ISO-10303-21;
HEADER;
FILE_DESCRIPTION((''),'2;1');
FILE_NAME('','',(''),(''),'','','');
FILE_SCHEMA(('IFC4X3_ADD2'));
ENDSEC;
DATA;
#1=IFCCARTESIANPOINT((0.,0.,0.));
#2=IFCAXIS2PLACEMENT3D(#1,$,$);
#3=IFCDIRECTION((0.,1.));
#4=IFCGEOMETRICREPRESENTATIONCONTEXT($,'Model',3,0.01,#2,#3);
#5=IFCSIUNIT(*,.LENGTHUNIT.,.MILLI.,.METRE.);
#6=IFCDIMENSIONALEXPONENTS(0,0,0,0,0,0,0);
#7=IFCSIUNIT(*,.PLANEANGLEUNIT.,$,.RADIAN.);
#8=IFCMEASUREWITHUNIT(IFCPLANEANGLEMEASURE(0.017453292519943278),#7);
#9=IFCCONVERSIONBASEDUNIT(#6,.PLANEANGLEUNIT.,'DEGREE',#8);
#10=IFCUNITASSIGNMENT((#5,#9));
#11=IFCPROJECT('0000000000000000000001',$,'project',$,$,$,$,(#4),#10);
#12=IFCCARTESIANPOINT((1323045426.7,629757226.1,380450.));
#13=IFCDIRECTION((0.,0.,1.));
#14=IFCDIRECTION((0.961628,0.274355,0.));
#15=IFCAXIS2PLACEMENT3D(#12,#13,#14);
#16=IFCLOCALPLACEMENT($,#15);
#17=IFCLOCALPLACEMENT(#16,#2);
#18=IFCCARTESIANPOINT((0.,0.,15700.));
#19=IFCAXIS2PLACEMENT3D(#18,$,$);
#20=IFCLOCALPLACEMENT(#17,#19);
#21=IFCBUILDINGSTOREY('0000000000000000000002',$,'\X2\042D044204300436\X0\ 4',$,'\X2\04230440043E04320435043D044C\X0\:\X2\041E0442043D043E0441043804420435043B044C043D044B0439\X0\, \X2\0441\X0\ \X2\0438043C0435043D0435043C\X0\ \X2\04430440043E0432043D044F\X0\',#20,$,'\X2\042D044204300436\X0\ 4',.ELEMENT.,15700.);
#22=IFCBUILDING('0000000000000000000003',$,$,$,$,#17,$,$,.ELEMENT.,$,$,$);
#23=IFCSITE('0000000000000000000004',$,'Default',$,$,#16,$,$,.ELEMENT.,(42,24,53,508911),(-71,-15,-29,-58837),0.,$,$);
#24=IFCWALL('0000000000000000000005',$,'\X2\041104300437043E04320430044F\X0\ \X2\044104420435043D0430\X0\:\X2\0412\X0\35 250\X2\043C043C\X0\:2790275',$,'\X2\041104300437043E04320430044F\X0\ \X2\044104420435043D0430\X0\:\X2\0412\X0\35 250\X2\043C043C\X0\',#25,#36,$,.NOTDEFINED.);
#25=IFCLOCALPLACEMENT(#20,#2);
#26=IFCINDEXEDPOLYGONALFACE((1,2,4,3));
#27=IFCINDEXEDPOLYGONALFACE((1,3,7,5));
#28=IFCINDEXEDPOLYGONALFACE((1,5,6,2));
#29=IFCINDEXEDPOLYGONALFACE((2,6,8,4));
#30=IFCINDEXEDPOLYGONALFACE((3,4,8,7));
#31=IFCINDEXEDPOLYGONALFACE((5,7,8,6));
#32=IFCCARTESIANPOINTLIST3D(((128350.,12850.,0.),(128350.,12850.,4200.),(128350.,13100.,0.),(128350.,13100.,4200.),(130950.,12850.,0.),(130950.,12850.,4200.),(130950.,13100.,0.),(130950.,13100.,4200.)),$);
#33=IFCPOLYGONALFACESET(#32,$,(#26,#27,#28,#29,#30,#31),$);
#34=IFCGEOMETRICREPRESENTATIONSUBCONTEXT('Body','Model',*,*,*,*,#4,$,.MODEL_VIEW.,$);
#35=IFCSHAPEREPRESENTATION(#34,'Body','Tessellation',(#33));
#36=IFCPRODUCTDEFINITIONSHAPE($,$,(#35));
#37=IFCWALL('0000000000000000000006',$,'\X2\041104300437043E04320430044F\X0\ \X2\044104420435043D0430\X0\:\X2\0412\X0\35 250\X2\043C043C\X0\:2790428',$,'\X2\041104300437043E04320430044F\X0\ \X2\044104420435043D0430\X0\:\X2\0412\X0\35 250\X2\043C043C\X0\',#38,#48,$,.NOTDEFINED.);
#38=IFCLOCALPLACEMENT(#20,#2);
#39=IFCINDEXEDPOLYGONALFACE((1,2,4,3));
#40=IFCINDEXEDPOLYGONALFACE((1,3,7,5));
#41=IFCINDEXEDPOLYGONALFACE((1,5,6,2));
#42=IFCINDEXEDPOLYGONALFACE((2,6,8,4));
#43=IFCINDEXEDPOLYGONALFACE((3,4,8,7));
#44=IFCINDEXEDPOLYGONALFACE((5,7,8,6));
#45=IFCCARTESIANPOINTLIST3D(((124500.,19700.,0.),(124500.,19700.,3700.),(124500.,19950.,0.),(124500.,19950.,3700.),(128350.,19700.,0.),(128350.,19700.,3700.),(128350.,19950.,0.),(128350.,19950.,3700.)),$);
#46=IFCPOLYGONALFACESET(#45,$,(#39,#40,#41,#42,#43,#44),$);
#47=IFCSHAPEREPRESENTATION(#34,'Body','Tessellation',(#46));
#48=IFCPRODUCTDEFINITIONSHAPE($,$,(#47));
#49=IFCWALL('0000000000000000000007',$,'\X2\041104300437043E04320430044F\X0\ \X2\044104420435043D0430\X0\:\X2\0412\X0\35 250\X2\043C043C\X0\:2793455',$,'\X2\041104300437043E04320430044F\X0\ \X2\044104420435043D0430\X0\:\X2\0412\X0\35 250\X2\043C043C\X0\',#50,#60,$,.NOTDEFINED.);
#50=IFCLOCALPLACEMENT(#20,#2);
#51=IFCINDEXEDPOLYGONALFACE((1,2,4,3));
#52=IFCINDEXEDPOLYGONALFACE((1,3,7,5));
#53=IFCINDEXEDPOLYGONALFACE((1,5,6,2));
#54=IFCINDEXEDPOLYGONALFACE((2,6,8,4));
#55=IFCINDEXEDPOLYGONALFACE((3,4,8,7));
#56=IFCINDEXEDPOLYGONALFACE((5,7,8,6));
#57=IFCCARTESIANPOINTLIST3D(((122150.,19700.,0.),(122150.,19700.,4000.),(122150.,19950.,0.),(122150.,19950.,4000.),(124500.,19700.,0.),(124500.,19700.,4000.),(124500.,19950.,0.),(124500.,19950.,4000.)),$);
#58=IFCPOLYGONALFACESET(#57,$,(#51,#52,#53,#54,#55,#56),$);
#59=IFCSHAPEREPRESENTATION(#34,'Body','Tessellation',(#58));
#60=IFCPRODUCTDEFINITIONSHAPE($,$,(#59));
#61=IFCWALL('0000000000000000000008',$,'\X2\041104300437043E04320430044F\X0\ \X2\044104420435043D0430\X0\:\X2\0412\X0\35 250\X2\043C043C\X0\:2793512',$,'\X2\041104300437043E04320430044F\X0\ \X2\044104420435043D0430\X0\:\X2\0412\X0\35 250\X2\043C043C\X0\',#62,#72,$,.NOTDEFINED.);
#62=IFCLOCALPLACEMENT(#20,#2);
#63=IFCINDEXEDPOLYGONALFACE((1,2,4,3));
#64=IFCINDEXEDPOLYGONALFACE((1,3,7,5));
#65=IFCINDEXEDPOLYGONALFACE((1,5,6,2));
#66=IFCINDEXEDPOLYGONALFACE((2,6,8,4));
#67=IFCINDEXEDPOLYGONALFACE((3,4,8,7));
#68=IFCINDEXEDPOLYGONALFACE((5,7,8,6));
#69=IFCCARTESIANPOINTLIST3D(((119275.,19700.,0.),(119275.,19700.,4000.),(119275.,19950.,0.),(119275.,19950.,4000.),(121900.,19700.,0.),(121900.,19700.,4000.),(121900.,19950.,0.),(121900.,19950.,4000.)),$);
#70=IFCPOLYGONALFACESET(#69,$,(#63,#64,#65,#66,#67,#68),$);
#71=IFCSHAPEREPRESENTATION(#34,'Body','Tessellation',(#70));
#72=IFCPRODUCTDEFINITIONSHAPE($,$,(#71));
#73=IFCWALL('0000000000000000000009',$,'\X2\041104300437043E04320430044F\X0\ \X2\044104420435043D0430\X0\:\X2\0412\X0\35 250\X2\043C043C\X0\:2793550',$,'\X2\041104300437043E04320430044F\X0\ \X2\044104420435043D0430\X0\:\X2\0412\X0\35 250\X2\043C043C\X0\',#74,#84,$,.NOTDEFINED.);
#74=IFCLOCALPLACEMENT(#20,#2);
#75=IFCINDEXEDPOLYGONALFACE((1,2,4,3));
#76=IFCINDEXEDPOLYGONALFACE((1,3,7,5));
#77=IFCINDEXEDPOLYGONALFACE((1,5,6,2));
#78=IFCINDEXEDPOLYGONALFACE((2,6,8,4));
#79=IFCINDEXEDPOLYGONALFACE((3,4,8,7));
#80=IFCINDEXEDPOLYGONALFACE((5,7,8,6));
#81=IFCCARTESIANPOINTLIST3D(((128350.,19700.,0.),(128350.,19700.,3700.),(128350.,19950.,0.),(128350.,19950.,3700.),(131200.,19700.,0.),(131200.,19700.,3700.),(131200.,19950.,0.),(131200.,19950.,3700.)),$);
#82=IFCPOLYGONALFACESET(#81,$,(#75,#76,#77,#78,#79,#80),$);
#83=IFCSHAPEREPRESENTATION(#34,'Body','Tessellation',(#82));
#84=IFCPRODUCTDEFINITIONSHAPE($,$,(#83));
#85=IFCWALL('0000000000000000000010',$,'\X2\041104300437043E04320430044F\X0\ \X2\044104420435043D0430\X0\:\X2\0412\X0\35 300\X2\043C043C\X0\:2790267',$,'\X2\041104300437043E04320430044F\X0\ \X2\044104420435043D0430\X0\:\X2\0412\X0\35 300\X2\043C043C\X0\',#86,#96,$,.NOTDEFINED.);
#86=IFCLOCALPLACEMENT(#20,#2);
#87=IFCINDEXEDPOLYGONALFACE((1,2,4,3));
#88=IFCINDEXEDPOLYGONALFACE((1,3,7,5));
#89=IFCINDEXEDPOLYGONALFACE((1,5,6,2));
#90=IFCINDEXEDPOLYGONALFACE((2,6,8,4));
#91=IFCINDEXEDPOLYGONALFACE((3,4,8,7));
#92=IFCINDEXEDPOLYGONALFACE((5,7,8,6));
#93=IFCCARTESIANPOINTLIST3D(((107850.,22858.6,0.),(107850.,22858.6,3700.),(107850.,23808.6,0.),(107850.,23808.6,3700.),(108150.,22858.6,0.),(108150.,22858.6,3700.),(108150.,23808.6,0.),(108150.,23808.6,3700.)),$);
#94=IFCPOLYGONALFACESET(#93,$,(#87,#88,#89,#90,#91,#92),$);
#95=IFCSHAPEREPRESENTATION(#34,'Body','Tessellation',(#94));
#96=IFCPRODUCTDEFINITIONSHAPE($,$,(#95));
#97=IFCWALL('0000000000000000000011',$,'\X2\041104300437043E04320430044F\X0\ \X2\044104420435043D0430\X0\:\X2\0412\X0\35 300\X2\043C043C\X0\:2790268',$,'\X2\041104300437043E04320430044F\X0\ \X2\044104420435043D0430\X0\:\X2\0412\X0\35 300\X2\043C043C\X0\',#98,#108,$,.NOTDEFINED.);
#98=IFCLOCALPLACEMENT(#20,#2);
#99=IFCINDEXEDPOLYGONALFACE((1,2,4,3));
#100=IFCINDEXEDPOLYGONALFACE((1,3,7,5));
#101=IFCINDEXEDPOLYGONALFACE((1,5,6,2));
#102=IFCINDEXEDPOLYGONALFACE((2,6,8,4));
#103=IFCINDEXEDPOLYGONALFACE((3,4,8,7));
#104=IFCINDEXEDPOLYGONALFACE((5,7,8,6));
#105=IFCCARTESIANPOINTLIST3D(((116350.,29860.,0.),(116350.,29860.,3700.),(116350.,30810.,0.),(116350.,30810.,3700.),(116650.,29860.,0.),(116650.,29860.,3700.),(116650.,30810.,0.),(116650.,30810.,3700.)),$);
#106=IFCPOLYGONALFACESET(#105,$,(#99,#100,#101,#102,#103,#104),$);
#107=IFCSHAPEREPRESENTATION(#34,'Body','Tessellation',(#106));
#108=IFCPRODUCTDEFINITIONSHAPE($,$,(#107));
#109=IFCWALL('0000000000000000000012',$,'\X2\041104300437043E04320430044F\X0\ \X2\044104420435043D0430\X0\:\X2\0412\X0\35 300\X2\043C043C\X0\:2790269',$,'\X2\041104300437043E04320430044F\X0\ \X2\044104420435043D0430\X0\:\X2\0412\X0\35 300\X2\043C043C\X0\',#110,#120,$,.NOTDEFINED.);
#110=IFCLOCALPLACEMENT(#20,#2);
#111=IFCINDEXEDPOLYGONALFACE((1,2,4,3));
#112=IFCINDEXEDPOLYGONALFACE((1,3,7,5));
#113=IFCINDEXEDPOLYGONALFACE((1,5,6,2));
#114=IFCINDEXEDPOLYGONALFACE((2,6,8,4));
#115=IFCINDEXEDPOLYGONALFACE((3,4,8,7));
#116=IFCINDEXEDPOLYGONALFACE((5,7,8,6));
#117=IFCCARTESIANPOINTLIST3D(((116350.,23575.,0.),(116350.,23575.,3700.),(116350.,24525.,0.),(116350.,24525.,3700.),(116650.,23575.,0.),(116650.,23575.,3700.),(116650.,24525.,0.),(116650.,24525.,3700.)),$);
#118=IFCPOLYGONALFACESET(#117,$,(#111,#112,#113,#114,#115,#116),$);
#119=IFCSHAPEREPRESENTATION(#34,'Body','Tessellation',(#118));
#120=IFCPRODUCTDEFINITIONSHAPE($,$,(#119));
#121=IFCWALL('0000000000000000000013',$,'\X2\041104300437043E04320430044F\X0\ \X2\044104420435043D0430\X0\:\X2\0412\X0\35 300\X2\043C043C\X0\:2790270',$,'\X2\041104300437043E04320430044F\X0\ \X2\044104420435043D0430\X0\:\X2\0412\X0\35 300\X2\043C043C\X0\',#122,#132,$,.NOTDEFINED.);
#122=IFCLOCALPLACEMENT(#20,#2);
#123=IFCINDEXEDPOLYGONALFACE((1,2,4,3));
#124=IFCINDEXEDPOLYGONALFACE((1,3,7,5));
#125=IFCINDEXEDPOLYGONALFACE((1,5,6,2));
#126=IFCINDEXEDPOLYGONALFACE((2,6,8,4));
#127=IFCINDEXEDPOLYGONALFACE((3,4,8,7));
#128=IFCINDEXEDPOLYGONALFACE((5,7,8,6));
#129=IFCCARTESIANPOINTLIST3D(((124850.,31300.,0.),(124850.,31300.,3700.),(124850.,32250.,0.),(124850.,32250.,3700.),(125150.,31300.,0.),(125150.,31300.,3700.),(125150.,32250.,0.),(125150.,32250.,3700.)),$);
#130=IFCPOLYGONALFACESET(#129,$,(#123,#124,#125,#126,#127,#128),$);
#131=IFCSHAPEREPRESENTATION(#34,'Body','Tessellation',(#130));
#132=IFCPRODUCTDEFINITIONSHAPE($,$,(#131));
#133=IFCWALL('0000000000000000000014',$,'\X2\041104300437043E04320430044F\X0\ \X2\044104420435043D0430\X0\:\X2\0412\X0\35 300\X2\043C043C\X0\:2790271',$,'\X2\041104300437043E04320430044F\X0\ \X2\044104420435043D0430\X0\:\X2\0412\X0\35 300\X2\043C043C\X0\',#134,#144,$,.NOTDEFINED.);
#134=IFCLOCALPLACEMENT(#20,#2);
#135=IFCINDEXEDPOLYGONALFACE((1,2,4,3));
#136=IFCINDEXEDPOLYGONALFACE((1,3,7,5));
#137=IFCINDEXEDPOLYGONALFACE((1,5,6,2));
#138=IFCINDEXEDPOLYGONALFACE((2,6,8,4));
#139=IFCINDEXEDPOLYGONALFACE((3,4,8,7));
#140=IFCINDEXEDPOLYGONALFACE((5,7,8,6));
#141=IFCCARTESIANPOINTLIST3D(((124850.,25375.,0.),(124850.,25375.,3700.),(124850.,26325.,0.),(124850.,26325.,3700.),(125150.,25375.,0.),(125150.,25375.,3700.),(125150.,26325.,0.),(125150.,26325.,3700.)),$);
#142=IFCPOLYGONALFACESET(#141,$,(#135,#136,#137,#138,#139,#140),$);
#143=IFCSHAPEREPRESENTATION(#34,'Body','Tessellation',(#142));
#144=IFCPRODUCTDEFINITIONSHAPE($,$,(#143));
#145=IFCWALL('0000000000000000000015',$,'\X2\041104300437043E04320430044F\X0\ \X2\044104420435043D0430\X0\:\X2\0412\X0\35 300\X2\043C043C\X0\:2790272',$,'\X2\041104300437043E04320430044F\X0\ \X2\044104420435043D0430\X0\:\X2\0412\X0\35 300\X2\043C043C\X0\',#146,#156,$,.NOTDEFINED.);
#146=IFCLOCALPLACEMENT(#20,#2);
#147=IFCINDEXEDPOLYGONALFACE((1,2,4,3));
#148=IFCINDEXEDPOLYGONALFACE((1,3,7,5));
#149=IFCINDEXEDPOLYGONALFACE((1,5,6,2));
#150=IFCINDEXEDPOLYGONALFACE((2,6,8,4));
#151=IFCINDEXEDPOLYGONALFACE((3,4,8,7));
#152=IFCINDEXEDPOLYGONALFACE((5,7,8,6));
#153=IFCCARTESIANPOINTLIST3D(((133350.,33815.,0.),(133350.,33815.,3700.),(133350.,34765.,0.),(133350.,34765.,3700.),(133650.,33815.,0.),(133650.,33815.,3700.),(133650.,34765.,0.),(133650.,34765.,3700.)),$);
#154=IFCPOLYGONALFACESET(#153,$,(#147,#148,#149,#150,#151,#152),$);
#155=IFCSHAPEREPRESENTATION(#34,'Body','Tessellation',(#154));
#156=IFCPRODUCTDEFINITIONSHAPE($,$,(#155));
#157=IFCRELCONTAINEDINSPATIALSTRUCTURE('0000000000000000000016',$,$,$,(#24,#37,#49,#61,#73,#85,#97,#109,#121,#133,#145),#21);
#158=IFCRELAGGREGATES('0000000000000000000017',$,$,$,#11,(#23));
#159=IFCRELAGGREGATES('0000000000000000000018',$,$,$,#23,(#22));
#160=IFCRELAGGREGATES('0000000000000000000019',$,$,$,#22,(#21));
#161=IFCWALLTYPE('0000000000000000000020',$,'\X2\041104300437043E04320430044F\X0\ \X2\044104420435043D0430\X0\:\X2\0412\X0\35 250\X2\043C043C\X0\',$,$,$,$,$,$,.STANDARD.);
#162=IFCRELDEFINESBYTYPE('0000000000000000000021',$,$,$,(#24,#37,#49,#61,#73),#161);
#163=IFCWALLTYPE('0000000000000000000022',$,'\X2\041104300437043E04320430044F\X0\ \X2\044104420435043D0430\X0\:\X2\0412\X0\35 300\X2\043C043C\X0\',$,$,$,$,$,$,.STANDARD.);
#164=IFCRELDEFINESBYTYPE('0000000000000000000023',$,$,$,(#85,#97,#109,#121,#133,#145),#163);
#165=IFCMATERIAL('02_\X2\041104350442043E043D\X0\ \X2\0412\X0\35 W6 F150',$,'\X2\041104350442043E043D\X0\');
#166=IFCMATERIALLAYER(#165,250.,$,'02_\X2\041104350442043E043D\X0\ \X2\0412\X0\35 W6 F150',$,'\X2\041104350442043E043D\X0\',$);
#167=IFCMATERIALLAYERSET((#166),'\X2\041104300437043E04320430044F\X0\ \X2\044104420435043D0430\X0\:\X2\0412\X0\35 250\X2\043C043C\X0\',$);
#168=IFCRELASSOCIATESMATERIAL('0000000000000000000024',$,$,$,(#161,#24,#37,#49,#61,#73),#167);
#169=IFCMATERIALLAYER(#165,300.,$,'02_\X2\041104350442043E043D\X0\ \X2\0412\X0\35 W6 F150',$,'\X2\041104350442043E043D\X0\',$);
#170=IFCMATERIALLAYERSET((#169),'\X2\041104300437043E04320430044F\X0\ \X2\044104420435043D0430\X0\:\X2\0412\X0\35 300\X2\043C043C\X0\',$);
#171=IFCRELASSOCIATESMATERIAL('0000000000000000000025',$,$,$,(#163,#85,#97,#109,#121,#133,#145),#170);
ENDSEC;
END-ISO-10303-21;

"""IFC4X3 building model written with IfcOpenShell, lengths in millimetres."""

from ifc_helpers import new_model, entity, si_unit, converted_unit, direction, frame, frame_2d, origin, place, context, subcontext, project, spatial, rectangle, extrude, material, layer, layer_set, type_object, element, save


model = new_model("IFC4X3")

# Units and contexts
model_context = context("Model", 3, precision=0.01, world=origin(), true_north=direction((0.0, 1.0)))
body_context = subcontext(model_context, "Body", "Model", "MODEL_VIEW")
ifc_project = project(units=[si_unit("LENGTHUNIT", "METRE", prefix="MILLI"), converted_unit("PLANEANGLEUNIT", "DEGREE", entity("IfcPlaneAngleMeasure", 0.017453292519943278), si_unit("PLANEANGLEUNIT", "RADIAN"), dimensions=[0, 0, 0, 0, 0, 0, 0])], contexts=[model_context])

# Site, building, storey
site_placement = place(None, frame((1323045426.7, 629757226.1, 380450.0), z_axis=(0.0, 0.0, 1.0), x_axis=(0.961628, 0.274355, 0.0)))
site = spatial("IfcSite", under=ifc_project, at=site_placement, Name="Default", CompositionType="ELEMENT", RefLatitude=(42, 24, 53, 508911), RefLongitude=(-71, -15, -29, -58837), RefElevation=0.0)
building_placement = place(site_placement, origin())
building = spatial("IfcBuilding", under=site, at=building_placement, CompositionType="ELEMENT")
storey_placement = place(building_placement, frame((0.0, 0.0, 15700.0)))
storey = spatial("IfcBuildingStorey", under=building, at=storey_placement, Name="Этаж 4", ObjectType="Уровень:Относительный, с именем уровня", LongName="Этаж 4", CompositionType="ELEMENT", Elevation=15700.0)

# Shared definitions
ifc_material = material(Name="02_Бетон В35 W6 F150", Category="Бетон")
ifc_layer_1 = layer(ifc_material, 250.0, Name="02_Бетон В35 W6 F150", Category="Бетон")
ifc_layer_set_1 = layer_set([ifc_layer_1], Name="Базовая стена:В35 250мм")
wall_type_1 = type_object("IfcWallType", Name="Базовая стена:В35 250мм", PredefinedType="STANDARD", material=ifc_layer_set_1)

# Walls
for number, where, z_axis, x_axis, name in (
    (1, (130950.0, 12975.0, 0.0), (0.0, 0.0, 1.0), (-1.0, 0.0, 0.0), "Базовая стена:В35 250мм:2790275"),
):
    element("IfcWall", number, at=place(storey_placement, frame(where, z_axis=z_axis, x_axis=x_axis)), inside=storey, type_object=wall_type_1, material=ifc_layer_set_1, Name=name, ObjectType="Базовая стена:В35 250мм", PredefinedType="NOTDEFINED", context=body_context, shape_type="SweptSolid", body=[
        extrude(rectangle(XDim=2600.0, YDim=250.0, at=frame_2d((1300.0, 0.0), x_axis=(-1.0, 0.0))), origin(), (0.0, 0.0, 1.0), 4200.0),
    ])
wall_1_placement = place(storey_placement, frame((124500.0, 19825.0, 0.0)))
element("IfcWall", 2, at=wall_1_placement, inside=storey, type_object=wall_type_1, material=ifc_layer_set_1, Name="Базовая стена:В35 250мм:2790428", ObjectType="Базовая стена:В35 250мм", PredefinedType="NOTDEFINED", context=body_context, shape_type="SweptSolid", body=[
    extrude(rectangle(XDim=3850.0, YDim=250.0, at=frame_2d((1925.0, 0.0), x_axis=(-1.0, 0.0))), origin(), (0.0, 0.0, 1.0), 3700.0),
])
wall_2_placement = place(storey_placement, frame((122150.0, 19825.0, 0.0)))
element("IfcWall", 3, at=wall_2_placement, inside=storey, type_object=wall_type_1, material=ifc_layer_set_1, Name="Базовая стена:В35 250мм:2793455", ObjectType="Базовая стена:В35 250мм", PredefinedType="NOTDEFINED", context=body_context, shape_type="SweptSolid", body=[
    extrude(rectangle(XDim=2350.0, YDim=250.0, at=frame_2d((1175.0, 0.0), x_axis=(-1.0, 0.0))), origin(), (0.0, 0.0, 1.0), 4000.0),
])
wall_3_placement = place(storey_placement, frame((119275.0, 19825.0, 0.0)))
element("IfcWall", 4, at=wall_3_placement, inside=storey, type_object=wall_type_1, material=ifc_layer_set_1, Name="Базовая стена:В35 250мм:2793512", ObjectType="Базовая стена:В35 250мм", PredefinedType="NOTDEFINED", context=body_context, shape_type="SweptSolid", body=[
    extrude(rectangle(XDim=2625.0, YDim=250.0, at=frame_2d((1312.5, 0.0), x_axis=(-1.0, 0.0))), origin(), (0.0, 0.0, 1.0), 4000.0),
])
wall_4_placement = place(storey_placement, frame((128350.0, 19825.0, 0.0)))
element("IfcWall", 5, at=wall_4_placement, inside=storey, type_object=wall_type_1, material=ifc_layer_set_1, Name="Базовая стена:В35 250мм:2793550", ObjectType="Базовая стена:В35 250мм", PredefinedType="NOTDEFINED", context=body_context, shape_type="SweptSolid", body=[
    extrude(rectangle(XDim=2850.0, YDim=250.0, at=frame_2d((1425.0, 0.0), x_axis=(-1.0, 0.0))), origin(), (0.0, 0.0, 1.0), 3700.0),
])
ifc_layer_2 = layer(ifc_material, 300.0, Name="02_Бетон В35 W6 F150", Category="Бетон")
ifc_layer_set_2 = layer_set([ifc_layer_2], Name="Базовая стена:В35 300мм")
wall_type_2 = type_object("IfcWallType", Name="Базовая стена:В35 300мм", PredefinedType="STANDARD", material=ifc_layer_set_2)
for number, where, z_axis, x_axis, name in (
    (6, (108000.0, 22858.6, 0.0), (0.0, 0.0, 1.0), (0.0, 1.0, 0.0), "Базовая стена:В35 300мм:2790267"),
    (7, (116500.0, 29860.0, 0.0), (0.0, 0.0, 1.0), (0.0, 1.0, 0.0), "Базовая стена:В35 300мм:2790268"),
    (8, (116500.0, 23575.0, 0.0), (0.0, 0.0, 1.0), (0.0, 1.0, 0.0), "Базовая стена:В35 300мм:2790269"),
    (9, (125000.0, 31300.0, 0.0), (0.0, 0.0, 1.0), (0.0, 1.0, 0.0), "Базовая стена:В35 300мм:2790270"),
    (10, (125000.0, 25375.0, 0.0), (0.0, 0.0, 1.0), (0.0, 1.0, 0.0), "Базовая стена:В35 300мм:2790271"),
    (11, (133500.0, 33815.0, 0.0), (0.0, 0.0, 1.0), (0.0, 1.0, 0.0), "Базовая стена:В35 300мм:2790272"),
):
    element("IfcWall", number, at=place(storey_placement, frame(where, z_axis=z_axis, x_axis=x_axis)), inside=storey, type_object=wall_type_2, material=ifc_layer_set_2, Name=name, ObjectType="Базовая стена:В35 300мм", PredefinedType="NOTDEFINED", context=body_context, shape_type="SweptSolid", body=[
        extrude(rectangle(XDim=950.0, YDim=300.0, at=frame_2d((475.0, 0.0), x_axis=(-1.0, 0.0))), origin(), (0.0, 0.0, 1.0), 3700.0),
    ])

save(model, "model.ifc")
